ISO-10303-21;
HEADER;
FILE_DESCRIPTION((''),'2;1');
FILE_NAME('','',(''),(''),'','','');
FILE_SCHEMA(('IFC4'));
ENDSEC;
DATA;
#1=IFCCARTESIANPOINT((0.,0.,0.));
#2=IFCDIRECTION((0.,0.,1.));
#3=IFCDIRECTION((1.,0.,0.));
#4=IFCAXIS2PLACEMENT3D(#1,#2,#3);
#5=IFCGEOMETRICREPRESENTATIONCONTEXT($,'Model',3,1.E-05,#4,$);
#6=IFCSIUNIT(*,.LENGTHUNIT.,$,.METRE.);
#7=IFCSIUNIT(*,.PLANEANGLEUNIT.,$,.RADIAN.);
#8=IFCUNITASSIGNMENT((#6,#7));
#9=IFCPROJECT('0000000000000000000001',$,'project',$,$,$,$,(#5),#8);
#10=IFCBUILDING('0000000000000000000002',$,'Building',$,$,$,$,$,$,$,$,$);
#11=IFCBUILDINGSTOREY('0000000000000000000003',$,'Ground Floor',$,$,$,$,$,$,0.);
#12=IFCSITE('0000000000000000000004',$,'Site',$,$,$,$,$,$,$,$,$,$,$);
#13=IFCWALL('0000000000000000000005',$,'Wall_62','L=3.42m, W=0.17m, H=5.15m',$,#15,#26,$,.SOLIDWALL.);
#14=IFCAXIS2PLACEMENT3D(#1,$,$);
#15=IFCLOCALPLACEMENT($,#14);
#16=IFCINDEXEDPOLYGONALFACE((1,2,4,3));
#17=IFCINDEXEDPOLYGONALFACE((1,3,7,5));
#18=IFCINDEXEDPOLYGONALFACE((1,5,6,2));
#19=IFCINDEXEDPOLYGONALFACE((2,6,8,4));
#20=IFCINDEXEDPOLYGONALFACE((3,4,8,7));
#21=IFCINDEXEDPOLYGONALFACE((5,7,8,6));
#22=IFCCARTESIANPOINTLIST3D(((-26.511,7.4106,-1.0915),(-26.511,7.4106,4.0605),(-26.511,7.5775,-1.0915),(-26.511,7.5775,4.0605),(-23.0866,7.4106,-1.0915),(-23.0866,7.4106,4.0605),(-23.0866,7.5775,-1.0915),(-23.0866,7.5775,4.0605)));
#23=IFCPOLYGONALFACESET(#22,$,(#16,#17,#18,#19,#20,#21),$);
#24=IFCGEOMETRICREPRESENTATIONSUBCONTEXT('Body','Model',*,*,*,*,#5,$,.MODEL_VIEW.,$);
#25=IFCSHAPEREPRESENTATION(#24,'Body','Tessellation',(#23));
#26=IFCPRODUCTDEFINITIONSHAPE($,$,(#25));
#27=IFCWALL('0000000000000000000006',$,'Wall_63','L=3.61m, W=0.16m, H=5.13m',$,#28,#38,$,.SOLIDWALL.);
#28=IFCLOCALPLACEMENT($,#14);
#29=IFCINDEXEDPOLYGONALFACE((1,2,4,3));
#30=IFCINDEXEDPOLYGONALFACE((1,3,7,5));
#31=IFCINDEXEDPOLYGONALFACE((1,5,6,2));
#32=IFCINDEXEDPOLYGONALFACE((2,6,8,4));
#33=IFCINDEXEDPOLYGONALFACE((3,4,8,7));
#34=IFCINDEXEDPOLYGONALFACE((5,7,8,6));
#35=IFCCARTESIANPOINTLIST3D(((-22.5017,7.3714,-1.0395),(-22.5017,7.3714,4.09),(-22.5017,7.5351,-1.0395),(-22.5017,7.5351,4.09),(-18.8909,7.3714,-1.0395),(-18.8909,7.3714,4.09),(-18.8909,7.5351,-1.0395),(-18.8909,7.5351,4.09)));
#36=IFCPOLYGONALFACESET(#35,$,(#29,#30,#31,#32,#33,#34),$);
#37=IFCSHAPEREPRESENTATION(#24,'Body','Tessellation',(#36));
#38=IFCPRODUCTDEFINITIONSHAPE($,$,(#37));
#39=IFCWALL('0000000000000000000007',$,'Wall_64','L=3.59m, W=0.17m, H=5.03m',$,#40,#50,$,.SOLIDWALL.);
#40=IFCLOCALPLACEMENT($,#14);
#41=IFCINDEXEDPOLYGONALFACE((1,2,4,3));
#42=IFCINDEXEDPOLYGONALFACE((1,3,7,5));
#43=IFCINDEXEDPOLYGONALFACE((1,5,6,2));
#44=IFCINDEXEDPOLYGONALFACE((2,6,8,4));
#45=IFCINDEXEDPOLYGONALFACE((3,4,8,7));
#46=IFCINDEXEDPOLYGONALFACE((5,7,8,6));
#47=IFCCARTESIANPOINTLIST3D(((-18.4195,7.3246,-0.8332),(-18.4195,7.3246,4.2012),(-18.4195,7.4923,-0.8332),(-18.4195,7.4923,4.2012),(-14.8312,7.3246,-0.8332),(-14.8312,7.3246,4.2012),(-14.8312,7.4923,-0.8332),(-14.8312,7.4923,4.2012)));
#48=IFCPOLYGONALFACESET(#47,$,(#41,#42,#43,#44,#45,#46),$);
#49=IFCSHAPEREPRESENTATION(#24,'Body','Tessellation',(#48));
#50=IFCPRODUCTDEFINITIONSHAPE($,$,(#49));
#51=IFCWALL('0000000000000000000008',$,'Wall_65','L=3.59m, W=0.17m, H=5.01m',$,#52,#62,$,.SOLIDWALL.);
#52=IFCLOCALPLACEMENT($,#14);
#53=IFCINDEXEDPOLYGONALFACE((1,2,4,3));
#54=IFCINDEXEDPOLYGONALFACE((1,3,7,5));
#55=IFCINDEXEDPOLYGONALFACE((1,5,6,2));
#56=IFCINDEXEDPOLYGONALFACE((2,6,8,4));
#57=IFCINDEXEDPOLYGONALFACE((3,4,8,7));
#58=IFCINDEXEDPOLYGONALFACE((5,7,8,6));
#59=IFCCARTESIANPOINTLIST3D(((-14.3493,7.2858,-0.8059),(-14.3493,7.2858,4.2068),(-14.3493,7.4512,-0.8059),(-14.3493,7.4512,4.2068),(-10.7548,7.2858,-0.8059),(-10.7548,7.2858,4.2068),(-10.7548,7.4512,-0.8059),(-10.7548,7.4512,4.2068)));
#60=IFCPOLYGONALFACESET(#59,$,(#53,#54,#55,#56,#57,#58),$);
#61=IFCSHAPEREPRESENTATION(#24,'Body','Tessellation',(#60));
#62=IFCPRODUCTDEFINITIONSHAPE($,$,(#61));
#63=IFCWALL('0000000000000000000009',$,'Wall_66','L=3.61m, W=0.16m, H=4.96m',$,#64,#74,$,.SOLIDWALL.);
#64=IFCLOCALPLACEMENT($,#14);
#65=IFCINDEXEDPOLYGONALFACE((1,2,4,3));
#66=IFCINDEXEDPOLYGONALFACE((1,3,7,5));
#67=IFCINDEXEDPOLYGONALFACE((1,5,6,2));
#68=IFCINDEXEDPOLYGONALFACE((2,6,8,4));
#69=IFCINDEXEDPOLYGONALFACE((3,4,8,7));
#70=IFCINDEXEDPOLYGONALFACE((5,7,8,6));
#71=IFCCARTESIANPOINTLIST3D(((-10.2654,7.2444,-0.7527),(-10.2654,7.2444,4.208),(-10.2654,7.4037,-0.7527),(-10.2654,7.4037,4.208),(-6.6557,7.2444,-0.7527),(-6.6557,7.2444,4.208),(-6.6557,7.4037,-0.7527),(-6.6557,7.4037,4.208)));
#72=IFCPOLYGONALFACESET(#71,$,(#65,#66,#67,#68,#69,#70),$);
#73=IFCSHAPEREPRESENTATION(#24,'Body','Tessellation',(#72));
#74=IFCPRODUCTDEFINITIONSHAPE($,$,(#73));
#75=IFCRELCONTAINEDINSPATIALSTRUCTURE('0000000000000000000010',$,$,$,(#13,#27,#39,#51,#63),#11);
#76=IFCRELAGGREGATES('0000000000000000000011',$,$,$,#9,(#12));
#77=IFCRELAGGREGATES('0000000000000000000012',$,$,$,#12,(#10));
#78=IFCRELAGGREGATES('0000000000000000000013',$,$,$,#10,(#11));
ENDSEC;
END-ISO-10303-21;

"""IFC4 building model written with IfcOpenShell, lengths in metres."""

from ifc_helpers import new_model, si_unit, frame, origin_with_axes, origin_2d, context, subcontext, project, spatial, rectangle, extrude, element, save


model = new_model("IFC4")

# Units and contexts
model_context = context("Model", 3, precision=1e-05, world=origin_with_axes())
body_context = subcontext(model_context, "Body", "Model", "MODEL_VIEW")
ifc_project = project(units=[si_unit("LENGTHUNIT", "METRE"), si_unit("PLANEANGLEUNIT", "RADIAN")], contexts=[model_context])

# Site, building, storey
site = spatial("IfcSite", under=ifc_project, Name="Site")
building = spatial("IfcBuilding", under=site, Name="Building")
storey = spatial("IfcBuildingStorey", under=building, Name="Ground Floor", Elevation=0.0)

# Walls
element("IfcWall", 1, inside=storey, Name="Wall_62", Description="L=3.42m, W=0.17m, H=5.15m", PredefinedType="SOLIDWALL", context=body_context, shape_type="SweptSolid", body=[
    extrude(rectangle(XDim=3.4244, YDim=0.1669, at=origin_2d()), frame((-24.7988, 7.494, -1.0915), z_axis=(0.0, 0.0, 1.0), x_axis=(1.0, 0.0, 0.0)), (0.0, 0.0, 1.0), 5.152),
])
element("IfcWall", 2, inside=storey, Name="Wall_63", Description="L=3.61m, W=0.16m, H=5.13m", PredefinedType="SOLIDWALL", context=body_context, shape_type="SweptSolid", body=[
    extrude(rectangle(XDim=3.6108, YDim=0.1637, at=origin_2d()), frame((-20.6963, 7.4533, -1.0395), z_axis=(0.0, 0.0, 1.0), x_axis=(1.0, 0.0, 0.0)), (0.0, 0.0, 1.0), 5.1295),
])
element("IfcWall", 3, inside=storey, Name="Wall_64", Description="L=3.59m, W=0.17m, H=5.03m", PredefinedType="SOLIDWALL", context=body_context, shape_type="SweptSolid", body=[
    extrude(rectangle(XDim=3.5883, YDim=0.1677, at=origin_2d()), frame((-16.6253, 7.4085, -0.8332), z_axis=(0.0, 0.0, 1.0), x_axis=(1.0, 0.0, 0.0)), (0.0, 0.0, 1.0), 5.0343),
])
element("IfcWall", 4, inside=storey, Name="Wall_65", Description="L=3.59m, W=0.17m, H=5.01m", PredefinedType="SOLIDWALL", context=body_context, shape_type="SweptSolid", body=[
    extrude(rectangle(XDim=3.5945, YDim=0.1655, at=origin_2d()), frame((-12.552, 7.3685, -0.8059), z_axis=(0.0, 0.0, 1.0), x_axis=(1.0, 0.0, 0.0)), (0.0, 0.0, 1.0), 5.0127),
])
element("IfcWall", 5, inside=storey, Name="Wall_66", Description="L=3.61m, W=0.16m, H=4.96m", PredefinedType="SOLIDWALL", context=body_context, shape_type="SweptSolid", body=[
    extrude(rectangle(XDim=3.6097, YDim=0.1593, at=origin_2d()), frame((-8.4605, 7.324, -0.7527), z_axis=(0.0, 0.0, 1.0), x_axis=(1.0, 0.0, 0.0)), (0.0, 0.0, 1.0), 4.9606),
])

save(model, "model.ifc")
